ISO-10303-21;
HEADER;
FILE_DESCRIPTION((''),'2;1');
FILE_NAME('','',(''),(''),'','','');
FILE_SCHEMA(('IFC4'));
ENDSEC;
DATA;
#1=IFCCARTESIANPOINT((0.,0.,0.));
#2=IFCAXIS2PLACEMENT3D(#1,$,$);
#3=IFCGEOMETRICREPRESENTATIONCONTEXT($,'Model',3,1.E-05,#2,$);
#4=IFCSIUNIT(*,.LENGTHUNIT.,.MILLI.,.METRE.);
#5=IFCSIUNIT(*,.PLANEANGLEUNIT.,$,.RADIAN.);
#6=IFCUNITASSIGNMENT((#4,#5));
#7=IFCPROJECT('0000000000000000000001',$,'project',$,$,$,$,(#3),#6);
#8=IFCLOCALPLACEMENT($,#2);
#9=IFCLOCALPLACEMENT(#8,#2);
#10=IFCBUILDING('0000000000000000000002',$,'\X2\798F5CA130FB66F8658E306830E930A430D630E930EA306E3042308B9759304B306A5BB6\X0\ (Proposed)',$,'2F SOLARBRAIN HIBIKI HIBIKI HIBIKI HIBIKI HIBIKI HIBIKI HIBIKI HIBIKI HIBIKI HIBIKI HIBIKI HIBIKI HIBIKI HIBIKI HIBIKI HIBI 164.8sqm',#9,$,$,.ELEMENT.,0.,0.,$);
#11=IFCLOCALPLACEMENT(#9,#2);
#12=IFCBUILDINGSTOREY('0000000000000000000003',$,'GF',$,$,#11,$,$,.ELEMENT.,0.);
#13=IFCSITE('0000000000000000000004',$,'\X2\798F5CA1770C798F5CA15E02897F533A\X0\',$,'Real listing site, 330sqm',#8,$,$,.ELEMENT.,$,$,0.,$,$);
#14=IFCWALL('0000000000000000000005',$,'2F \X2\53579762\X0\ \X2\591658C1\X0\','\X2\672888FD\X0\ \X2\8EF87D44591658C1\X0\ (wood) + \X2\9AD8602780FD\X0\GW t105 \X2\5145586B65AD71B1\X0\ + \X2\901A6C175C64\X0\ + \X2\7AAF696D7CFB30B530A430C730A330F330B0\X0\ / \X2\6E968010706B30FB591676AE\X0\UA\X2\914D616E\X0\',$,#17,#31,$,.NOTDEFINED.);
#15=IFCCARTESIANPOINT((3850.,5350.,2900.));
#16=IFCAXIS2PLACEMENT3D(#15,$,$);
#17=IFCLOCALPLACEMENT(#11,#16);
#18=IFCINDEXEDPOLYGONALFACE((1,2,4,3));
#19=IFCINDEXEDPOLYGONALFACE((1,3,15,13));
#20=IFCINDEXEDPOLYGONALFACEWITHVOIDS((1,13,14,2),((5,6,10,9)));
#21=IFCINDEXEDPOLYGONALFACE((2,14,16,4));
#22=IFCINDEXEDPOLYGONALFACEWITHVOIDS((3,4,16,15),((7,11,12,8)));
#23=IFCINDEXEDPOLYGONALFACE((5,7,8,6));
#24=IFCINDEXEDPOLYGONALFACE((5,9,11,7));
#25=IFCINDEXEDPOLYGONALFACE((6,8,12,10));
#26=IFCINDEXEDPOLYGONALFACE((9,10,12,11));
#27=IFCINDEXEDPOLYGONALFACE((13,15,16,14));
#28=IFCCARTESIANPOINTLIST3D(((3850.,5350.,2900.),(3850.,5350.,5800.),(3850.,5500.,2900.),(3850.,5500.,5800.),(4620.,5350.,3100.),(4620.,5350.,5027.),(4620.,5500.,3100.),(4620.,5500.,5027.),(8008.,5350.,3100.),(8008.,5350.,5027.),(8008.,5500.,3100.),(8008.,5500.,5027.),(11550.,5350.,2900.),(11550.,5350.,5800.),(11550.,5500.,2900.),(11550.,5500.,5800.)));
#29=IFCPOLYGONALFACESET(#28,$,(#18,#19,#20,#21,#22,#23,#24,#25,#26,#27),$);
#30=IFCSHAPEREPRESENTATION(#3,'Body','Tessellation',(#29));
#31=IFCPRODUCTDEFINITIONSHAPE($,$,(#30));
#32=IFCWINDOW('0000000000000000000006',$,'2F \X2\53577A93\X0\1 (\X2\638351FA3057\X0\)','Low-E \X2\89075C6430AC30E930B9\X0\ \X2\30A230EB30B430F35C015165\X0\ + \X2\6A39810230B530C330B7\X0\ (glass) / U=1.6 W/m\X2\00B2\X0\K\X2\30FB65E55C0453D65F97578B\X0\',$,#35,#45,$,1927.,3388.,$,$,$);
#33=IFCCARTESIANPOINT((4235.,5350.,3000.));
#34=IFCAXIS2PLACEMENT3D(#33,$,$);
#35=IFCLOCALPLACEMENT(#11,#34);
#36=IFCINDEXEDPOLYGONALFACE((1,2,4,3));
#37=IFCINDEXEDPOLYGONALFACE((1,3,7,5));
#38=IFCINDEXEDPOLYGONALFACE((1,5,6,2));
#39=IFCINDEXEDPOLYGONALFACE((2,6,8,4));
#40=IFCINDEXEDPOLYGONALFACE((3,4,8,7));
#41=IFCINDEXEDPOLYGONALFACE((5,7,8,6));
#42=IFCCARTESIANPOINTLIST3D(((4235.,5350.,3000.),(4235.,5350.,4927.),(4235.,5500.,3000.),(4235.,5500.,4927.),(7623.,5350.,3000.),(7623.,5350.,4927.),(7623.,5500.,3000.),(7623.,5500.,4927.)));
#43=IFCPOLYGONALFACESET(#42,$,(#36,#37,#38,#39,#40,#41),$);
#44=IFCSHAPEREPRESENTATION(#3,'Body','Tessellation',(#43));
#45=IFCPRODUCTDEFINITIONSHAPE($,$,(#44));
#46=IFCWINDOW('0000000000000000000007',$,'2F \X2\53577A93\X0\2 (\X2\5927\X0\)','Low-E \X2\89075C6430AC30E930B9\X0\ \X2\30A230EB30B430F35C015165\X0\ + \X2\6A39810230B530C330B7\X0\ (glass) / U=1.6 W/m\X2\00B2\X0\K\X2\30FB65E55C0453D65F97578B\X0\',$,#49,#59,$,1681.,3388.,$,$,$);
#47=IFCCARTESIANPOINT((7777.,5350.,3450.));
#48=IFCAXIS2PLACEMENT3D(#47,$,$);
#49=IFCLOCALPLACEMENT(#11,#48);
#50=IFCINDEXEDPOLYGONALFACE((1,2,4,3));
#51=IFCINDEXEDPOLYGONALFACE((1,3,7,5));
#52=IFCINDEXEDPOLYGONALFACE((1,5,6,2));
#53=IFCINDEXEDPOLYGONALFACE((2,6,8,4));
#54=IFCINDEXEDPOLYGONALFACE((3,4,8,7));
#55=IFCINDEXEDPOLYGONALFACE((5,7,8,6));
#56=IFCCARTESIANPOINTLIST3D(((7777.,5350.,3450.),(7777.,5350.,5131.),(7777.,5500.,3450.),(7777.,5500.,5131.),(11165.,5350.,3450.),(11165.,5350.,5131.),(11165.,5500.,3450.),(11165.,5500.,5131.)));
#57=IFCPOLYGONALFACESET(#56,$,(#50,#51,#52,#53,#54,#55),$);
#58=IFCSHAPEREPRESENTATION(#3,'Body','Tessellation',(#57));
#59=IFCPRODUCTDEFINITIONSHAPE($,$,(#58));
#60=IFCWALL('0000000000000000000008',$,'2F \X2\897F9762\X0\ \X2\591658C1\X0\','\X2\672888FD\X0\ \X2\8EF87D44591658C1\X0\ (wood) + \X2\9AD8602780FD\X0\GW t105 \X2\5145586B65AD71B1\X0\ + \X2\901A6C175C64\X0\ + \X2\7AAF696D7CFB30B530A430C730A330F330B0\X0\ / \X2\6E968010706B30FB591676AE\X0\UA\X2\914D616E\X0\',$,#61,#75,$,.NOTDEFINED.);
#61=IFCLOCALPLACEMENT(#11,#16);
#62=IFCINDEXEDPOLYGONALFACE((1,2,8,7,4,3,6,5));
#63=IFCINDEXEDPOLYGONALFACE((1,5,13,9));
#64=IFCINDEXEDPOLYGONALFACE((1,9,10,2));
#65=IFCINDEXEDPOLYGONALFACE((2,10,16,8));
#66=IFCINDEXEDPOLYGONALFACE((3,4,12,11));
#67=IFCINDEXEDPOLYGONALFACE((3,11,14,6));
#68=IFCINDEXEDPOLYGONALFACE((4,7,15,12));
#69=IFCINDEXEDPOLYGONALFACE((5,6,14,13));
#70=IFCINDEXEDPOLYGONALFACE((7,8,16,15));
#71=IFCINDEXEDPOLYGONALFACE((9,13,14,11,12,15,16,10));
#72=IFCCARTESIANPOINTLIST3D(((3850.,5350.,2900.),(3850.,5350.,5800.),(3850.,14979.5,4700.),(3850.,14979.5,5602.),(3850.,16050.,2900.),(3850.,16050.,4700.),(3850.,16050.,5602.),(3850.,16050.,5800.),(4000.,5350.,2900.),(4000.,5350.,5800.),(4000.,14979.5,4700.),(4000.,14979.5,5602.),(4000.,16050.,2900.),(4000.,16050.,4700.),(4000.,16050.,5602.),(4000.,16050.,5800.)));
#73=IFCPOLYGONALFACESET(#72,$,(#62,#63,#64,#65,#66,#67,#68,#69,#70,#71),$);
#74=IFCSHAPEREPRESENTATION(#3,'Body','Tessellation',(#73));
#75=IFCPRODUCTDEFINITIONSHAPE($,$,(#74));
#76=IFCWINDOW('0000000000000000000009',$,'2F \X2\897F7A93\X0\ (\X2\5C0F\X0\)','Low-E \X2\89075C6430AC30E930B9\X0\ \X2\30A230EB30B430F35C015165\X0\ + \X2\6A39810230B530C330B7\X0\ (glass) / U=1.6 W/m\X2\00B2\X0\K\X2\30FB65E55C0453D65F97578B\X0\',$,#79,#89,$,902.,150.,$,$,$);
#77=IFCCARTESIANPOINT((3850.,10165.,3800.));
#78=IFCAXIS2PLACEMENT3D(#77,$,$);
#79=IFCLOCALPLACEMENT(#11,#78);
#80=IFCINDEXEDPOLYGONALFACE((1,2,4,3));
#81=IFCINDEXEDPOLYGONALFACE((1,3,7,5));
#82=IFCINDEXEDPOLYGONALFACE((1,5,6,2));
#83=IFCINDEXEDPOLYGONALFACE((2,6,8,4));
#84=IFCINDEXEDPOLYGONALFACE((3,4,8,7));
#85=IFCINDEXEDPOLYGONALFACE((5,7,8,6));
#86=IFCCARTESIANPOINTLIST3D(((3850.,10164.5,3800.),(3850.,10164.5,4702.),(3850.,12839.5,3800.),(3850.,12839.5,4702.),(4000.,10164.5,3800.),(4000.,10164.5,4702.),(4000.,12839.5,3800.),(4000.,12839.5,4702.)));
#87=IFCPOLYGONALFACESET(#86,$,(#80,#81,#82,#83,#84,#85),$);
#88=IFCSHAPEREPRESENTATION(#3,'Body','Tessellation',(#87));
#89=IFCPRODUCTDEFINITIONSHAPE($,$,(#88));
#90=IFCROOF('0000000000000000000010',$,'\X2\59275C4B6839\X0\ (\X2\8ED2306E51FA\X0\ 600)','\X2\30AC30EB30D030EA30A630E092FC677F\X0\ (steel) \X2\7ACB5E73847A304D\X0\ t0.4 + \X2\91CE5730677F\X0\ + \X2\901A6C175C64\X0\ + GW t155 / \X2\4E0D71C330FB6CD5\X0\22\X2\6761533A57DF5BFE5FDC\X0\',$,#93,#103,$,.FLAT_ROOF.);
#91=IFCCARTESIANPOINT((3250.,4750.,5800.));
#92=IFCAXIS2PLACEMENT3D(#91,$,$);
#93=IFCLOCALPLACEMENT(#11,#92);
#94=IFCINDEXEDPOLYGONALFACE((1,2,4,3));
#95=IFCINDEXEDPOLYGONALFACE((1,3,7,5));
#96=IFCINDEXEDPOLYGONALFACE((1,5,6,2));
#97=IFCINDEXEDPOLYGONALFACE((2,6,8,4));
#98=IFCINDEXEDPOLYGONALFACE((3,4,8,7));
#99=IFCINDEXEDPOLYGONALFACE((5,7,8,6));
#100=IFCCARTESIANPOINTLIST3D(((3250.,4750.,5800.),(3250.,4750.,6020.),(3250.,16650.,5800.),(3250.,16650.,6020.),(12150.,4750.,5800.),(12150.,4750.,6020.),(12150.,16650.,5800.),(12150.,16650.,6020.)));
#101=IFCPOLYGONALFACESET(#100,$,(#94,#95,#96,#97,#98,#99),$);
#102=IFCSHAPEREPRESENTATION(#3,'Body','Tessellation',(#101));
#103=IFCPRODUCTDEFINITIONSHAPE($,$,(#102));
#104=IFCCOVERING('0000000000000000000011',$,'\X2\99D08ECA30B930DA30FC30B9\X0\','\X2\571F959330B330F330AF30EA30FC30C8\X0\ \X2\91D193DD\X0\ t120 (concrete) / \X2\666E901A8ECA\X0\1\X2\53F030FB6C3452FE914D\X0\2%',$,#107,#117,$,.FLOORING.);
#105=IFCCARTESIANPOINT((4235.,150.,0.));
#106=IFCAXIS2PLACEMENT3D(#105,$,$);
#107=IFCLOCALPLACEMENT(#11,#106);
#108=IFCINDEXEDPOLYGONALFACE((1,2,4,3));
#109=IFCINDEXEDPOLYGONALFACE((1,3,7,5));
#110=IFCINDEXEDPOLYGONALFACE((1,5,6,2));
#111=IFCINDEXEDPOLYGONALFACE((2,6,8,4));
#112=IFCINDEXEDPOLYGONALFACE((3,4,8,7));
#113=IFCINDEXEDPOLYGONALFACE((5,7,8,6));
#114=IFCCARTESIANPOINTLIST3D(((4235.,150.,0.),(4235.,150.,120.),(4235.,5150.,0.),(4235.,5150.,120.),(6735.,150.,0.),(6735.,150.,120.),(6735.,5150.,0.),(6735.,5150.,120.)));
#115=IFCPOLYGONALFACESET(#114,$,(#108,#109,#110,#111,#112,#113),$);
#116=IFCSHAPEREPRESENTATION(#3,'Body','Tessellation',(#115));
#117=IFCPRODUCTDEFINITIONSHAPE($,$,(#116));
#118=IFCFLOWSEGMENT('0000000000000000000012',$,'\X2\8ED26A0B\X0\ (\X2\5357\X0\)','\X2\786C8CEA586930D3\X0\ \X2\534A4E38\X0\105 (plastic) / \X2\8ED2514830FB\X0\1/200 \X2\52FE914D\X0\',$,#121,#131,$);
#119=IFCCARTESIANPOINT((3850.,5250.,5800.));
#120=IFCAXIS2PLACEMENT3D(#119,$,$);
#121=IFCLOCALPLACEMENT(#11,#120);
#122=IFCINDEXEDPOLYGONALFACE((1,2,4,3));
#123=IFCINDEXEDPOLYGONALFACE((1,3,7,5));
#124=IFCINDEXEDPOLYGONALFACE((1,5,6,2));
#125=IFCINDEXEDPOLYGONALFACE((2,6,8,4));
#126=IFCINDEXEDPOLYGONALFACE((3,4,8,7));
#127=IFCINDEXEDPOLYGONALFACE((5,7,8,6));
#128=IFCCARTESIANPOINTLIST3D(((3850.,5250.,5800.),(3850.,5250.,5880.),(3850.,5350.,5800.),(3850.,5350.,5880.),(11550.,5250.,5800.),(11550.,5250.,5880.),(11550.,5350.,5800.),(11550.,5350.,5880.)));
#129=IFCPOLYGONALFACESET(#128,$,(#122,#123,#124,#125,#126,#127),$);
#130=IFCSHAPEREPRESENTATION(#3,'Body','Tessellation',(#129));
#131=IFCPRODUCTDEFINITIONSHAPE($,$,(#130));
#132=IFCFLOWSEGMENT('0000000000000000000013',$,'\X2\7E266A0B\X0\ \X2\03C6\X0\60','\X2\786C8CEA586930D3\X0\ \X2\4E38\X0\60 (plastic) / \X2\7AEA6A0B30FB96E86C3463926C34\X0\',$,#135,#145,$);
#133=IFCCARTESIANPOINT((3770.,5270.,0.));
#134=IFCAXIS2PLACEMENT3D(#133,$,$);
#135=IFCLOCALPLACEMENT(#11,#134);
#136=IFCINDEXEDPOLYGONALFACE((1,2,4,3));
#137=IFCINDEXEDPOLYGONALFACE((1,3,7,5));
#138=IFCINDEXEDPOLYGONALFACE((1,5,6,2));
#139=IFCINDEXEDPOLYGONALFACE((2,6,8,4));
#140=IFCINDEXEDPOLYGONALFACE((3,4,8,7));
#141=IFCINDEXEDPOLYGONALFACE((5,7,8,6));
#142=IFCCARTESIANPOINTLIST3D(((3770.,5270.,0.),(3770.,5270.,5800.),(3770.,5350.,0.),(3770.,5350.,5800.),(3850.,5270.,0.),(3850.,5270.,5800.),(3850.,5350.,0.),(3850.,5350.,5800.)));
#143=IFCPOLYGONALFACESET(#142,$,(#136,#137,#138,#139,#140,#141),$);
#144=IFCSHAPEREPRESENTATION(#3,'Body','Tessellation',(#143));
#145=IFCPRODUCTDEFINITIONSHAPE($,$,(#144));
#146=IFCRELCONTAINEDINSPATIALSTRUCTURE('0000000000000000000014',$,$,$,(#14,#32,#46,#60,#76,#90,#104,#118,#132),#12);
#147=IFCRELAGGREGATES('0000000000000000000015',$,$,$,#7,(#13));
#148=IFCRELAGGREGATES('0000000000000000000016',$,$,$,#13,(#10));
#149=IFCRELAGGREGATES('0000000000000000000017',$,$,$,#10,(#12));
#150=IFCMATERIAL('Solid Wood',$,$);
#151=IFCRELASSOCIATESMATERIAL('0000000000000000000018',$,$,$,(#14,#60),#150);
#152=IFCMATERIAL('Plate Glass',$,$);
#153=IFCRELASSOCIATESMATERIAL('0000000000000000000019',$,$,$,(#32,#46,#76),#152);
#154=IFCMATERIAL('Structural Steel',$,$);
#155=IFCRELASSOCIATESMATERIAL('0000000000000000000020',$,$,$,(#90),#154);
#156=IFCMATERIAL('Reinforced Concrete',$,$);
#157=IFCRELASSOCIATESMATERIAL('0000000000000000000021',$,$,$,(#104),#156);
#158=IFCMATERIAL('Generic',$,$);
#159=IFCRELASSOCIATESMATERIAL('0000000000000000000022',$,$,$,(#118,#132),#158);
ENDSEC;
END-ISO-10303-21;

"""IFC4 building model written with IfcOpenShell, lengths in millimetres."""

from ifc_helpers import new_model, si_unit, frame, frame_2d, origin, place, context, project, spatial, rectangle, extrude, material, element, fill, save


model = new_model("IFC4")

# Units and contexts
model_context = context("Model", 3, precision=1e-05, world=origin())
ifc_project = project(units=[si_unit("LENGTHUNIT", "METRE", prefix="MILLI"), si_unit("PLANEANGLEUNIT", "RADIAN")], contexts=[model_context])

# Site, building, storey
site_placement = place(None, origin())
site = spatial("IfcSite", under=ifc_project, at=site_placement, Name="福岡県福岡市西区", ObjectType="Real listing site, 330sqm", CompositionType="ELEMENT", RefElevation=0.0)
building_placement = place(site_placement, origin())
building = spatial("IfcBuilding", under=site, at=building_placement, Name="福岡・書斎とライブラリのある静かな家 (Proposed)", ObjectType="2F SOLARBRAIN HIBIKI HIBIKI HIBIKI HIBIKI HIBIKI HIBIKI HIBIKI HIBIKI HIBIKI HIBIKI HIBIKI HIBIKI HIBIKI HIBIKI HIBIKI HIBI 164.8sqm", CompositionType="ELEMENT", ElevationOfRefHeight=0.0, ElevationOfTerrain=0.0)
storey_placement = place(building_placement, origin())
storey = spatial("IfcBuildingStorey", under=building, at=storey_placement, Name="GF", CompositionType="ELEMENT", Elevation=0.0)

# Shared definitions
ifc_material_1 = material(Name="Solid Wood")

# Shared definitions
ifc_material_2 = material(Name="Reinforced Concrete")

# Shared definitions
ifc_material_3 = material(Name="Plate Glass")

# Wall, openings, windows
wall_1_placement = place(storey_placement, frame((3850.0, 5350.0, 2900.0)))
wall_1 = element("IfcWall", 1, at=wall_1_placement, inside=storey, material=ifc_material_1, Name="2F 南面 外壁", Description="木製 軸組外壁 (wood) + 高性能GW t105 充填断熱 + 通気層 + 窯業系サイディング / 準耐火・外皮UA配慮", PredefinedType="NOTDEFINED", context=model_context, shape_type="SweptSolid", body=[
    extrude(rectangle(XDim=7700.0, YDim=150.0, at=frame_2d((3850.0, 75.0))), frame((3850.0, 5350.0, 2900.0)), (0.0, 0.0, 1.0), 2900.0),
])
opening_1_placement = place(storey_placement, frame((4235.0, 5350.0, 3000.0)))
opening_1 = element("IfcOpeningElement", 2, at=opening_1_placement, cuts=wall_1, PredefinedType="NOTDEFINED", context=model_context, shape_type="SweptSolid", body=[
    extrude(rectangle(XDim=3388.0, YDim=150.0, at=frame_2d((1694.0, 75.0))), frame((4235.0, 5350.0, 3000.0)), (0.0, 0.0, 1.0), 1927.0),
])
opening_2_placement = place(storey_placement, frame((7777.0, 5350.0, 3450.0)))
opening_2 = element("IfcOpeningElement", 3, at=opening_2_placement, cuts=wall_1, PredefinedType="NOTDEFINED", context=model_context, shape_type="SweptSolid", body=[
    extrude(rectangle(XDim=3388.0, YDim=150.0, at=frame_2d((1694.0, 75.0))), frame((7777.0, 5350.0, 3450.0)), (0.0, 0.0, 1.0), 1681.0),
])
window_1_placement = place(storey_placement, frame((4235.0, 5350.0, 3000.0)))
window_1 = element("IfcWindow", 4, at=window_1_placement, inside=storey, material=ifc_material_3, Name="2F 南窓1 (掃出し)", Description="Low-E 複層ガラス アルゴン封入 + 樹脂サッシ (glass) / U=1.6 W/m²K・日射取得型", OverallHeight=1927.0, OverallWidth=3388.0, context=model_context, shape_type="SweptSolid", body=[
    extrude(rectangle(XDim=3388.0, YDim=150.0, at=frame_2d((1694.0, 75.0))), frame((4235.0, 5350.0, 3000.0)), (0.0, 0.0, 1.0), 1927.0),
])
fill(opening_1, window_1)
window_2_placement = place(storey_placement, frame((7777.0, 5350.0, 3450.0)))
window_2 = element("IfcWindow", 5, at=window_2_placement, inside=storey, material=ifc_material_3, Name="2F 南窓2 (大)", Description="Low-E 複層ガラス アルゴン封入 + 樹脂サッシ (glass) / U=1.6 W/m²K・日射取得型", OverallHeight=1681.0, OverallWidth=3388.0, context=model_context, shape_type="SweptSolid", body=[
    extrude(rectangle(XDim=3388.0, YDim=150.0, at=frame_2d((1694.0, 75.0))), frame((7777.0, 5350.0, 3450.0)), (0.0, 0.0, 1.0), 1681.0),
])
fill(opening_2, window_2)

# Wall, opening, window
wall_2_placement = place(storey_placement, frame((3850.0, 5350.0, 2900.0)))
wall_2 = element("IfcWall", 6, at=wall_2_placement, inside=storey, material=ifc_material_1, Name="2F 西面 外壁", Description="木製 軸組外壁 (wood) + 高性能GW t105 充填断熱 + 通気層 + 窯業系サイディング / 準耐火・外皮UA配慮", PredefinedType="NOTDEFINED", context=model_context, shape_type="SweptSolid", body=[
    extrude(rectangle(XDim=150.0, YDim=10700.0, at=frame_2d((75.0, 5350.0))), frame((3850.0, 5350.0, 2900.0)), (0.0, 0.0, 1.0), 2900.0),
])
opening_3_placement = place(storey_placement, frame((3850.0, 10165.0, 3800.0)))
opening_3 = element("IfcOpeningElement", 7, at=opening_3_placement, cuts=wall_2, PredefinedType="NOTDEFINED", context=model_context, shape_type="SweptSolid", body=[
    extrude(rectangle(XDim=150.0, YDim=2675.0, at=frame_2d((75.0, 1337.0))), frame((3850.0, 10165.0, 3800.0)), (0.0, 0.0, 1.0), 902.0),
])
window_3_placement = place(storey_placement, frame((3850.0, 10165.0, 3800.0)))
window_3 = element("IfcWindow", 8, at=window_3_placement, inside=storey, material=ifc_material_3, Name="2F 西窓 (小)", Description="Low-E 複層ガラス アルゴン封入 + 樹脂サッシ (glass) / U=1.6 W/m²K・日射取得型", OverallHeight=902.0, OverallWidth=150.0, context=model_context, shape_type="SweptSolid", body=[
    extrude(rectangle(XDim=150.0, YDim=2675.0, at=frame_2d((75.0, 1337.0))), frame((3850.0, 10165.0, 3800.0)), (0.0, 0.0, 1.0), 902.0),
])
fill(opening_3, window_3)

# Roof
ifc_material_4 = material(Name="Structural Steel")
roof_placement = place(storey_placement, frame((3250.0, 4750.0, 5800.0)))
element("IfcRoof", 9, at=roof_placement, inside=storey, material=ifc_material_4, Name="大屋根 (軒の出 600)", Description="ガルバリウム鋼板 (steel) 立平葺き t0.4 + 野地板 + 通気層 + GW t155 / 不燃・法22条区域対応", PredefinedType="FLAT_ROOF", context=model_context, shape_type="SweptSolid", body=[
    extrude(rectangle(XDim=8900.0, YDim=11900.0, at=frame_2d((4450.0, 5950.0))), frame((3250.0, 4750.0, 5800.0)), (0.0, 0.0, 1.0), 220.0),
])

# Covering
covering_placement = place(storey_placement, frame((4235.0, 150.0, 0.0)))
element("IfcCovering", 10, at=covering_placement, inside=storey, material=ifc_material_2, Name="駐車スペース", Description="土間コンクリート 金鏝 t120 (concrete) / 普通車1台・水勾配2%", PredefinedType="FLOORING", context=model_context, shape_type="SweptSolid", body=[
    extrude(rectangle(XDim=2500.0, YDim=5000.0, at=frame_2d((1250.0, 2500.0))), frame((4235.0, 150.0, 0.0)), (0.0, 0.0, 1.0), 120.0),
])

# Flow segments
ifc_material_5 = material(Name="Generic")
flow_segment_1_placement = place(storey_placement, frame((3850.0, 5250.0, 5800.0)))
element("IfcFlowSegment", 11, at=flow_segment_1_placement, inside=storey, material=ifc_material_5, Name="軒樋 (南)", Description="硬質塩ビ 半丸105 (plastic) / 軒先・1/200 勾配", context=model_context, shape_type="SweptSolid", body=[
    extrude(rectangle(XDim=7700.0, YDim=100.0, at=frame_2d((3850.0, 50.0))), frame((3850.0, 5250.0, 5800.0)), (0.0, 0.0, 1.0), 80.0),
])
flow_segment_2_placement = place(storey_placement, frame((3770.0, 5270.0, 0.0)))
element("IfcFlowSegment", 12, at=flow_segment_2_placement, inside=storey, material=ifc_material_5, Name="縦樋 φ60", Description="硬質塩ビ 丸60 (plastic) / 竪樋・雨水排水", context=model_context, shape_type="SweptSolid", body=[
    extrude(rectangle(XDim=80.0, YDim=80.0, at=frame_2d((40.0, 40.0))), frame((3770.0, 5270.0, 0.0)), (0.0, 0.0, 1.0), 5800.0),
])

save(model, "model.ifc")
